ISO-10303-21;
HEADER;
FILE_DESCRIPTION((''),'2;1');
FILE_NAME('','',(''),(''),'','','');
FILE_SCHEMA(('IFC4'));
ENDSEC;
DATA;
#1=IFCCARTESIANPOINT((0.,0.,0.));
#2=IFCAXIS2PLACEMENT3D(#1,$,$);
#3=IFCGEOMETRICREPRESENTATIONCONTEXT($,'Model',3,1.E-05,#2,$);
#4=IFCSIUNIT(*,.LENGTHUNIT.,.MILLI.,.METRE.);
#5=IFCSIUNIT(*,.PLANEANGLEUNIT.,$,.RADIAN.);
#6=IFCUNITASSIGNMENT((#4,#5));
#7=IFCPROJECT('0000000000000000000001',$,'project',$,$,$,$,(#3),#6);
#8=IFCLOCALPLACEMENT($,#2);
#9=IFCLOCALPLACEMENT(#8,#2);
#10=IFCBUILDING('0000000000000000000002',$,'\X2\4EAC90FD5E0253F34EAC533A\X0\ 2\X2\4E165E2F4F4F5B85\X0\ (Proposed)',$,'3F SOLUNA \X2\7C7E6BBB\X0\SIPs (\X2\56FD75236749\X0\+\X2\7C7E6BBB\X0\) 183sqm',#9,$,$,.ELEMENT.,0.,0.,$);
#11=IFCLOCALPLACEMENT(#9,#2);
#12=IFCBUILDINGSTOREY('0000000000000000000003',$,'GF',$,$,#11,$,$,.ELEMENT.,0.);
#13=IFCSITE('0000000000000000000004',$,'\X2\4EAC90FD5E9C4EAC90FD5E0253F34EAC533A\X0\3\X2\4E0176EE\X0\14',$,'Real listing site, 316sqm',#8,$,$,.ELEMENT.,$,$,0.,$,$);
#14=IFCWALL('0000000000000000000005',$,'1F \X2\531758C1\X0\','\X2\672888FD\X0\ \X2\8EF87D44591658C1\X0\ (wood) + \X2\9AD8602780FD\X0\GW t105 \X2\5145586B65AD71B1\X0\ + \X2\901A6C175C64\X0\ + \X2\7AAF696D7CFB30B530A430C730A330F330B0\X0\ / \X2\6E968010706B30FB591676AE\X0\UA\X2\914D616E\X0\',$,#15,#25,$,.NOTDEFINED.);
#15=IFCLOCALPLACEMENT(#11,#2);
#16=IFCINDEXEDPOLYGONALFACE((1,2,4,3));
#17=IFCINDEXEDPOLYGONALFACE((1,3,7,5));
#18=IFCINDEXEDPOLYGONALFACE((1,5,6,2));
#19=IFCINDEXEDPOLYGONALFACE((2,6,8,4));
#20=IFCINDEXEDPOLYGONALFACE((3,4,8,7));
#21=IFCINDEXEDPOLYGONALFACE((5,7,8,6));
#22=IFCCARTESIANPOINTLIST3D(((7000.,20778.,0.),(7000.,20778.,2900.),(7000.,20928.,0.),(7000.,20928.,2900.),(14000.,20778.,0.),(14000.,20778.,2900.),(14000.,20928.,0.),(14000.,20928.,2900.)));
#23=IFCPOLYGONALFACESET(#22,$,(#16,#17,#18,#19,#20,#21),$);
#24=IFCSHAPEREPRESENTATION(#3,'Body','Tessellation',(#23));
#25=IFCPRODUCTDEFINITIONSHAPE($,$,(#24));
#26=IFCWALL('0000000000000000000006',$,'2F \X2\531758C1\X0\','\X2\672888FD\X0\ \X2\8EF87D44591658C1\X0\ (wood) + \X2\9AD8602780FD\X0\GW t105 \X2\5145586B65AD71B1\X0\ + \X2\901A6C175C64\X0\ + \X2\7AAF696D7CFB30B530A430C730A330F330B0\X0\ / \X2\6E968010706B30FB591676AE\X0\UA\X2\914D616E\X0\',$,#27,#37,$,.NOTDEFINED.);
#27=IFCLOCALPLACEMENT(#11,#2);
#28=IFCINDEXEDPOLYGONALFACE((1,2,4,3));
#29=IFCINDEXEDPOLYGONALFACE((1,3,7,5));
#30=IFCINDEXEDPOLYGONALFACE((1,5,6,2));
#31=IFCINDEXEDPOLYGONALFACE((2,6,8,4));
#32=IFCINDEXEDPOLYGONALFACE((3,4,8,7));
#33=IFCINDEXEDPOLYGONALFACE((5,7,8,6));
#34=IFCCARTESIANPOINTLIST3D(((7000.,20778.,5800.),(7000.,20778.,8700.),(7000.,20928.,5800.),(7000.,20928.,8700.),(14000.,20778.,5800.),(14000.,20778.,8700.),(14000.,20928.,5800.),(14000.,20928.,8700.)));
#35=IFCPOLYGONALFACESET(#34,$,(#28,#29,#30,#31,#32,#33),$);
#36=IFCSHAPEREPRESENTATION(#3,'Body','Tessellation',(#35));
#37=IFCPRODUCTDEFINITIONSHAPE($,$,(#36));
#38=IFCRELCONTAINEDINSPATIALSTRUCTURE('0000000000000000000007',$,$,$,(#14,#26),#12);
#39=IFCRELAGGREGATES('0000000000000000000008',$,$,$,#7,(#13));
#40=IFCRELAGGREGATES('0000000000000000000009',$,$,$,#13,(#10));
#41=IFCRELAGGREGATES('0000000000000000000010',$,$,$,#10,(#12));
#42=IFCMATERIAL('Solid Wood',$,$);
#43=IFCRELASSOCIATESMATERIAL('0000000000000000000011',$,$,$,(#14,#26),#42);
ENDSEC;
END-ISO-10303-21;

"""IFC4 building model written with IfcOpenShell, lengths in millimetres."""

from ifc_helpers import new_model, si_unit, frame, frame_2d, origin, place, context, project, spatial, rectangle, extrude, material, element, save


model = new_model("IFC4")

# Units and contexts
model_context = context("Model", 3, precision=1e-05, world=origin())
ifc_project = project(units=[si_unit("LENGTHUNIT", "METRE", prefix="MILLI"), si_unit("PLANEANGLEUNIT", "RADIAN")], contexts=[model_context])

# Site, building, storey
site_placement = place(None, origin())
site = spatial("IfcSite", under=ifc_project, at=site_placement, Name="京都府京都市右京区3丁目14", ObjectType="Real listing site, 316sqm", CompositionType="ELEMENT", RefElevation=0.0)
building_placement = place(site_placement, origin())
building = spatial("IfcBuilding", under=site, at=building_placement, Name="京都市右京区 2世帯住宅 (Proposed)", ObjectType="3F SOLUNA 籾殻SIPs (国産杉+籾殻) 183sqm", CompositionType="ELEMENT", ElevationOfRefHeight=0.0, ElevationOfTerrain=0.0)
storey_placement = place(building_placement, origin())
storey = spatial("IfcBuildingStorey", under=building, at=storey_placement, Name="GF", CompositionType="ELEMENT", Elevation=0.0)

# Shared definitions
ifc_material_1 = material(Name="Solid Wood")

# Wall
wall_1_placement = place(storey_placement, frame((3500.0, 10389.0, 0.0)))
element("IfcWall", 1, at=wall_1_placement, inside=storey, material=ifc_material_1, Name="1F 北壁", Description="木製 軸組外壁 (wood) + 高性能GW t105 充填断熱 + 通気層 + 窯業系サイディング / 準耐火・外皮UA配慮", PredefinedType="NOTDEFINED", context=model_context, shape_type="SweptSolid", body=[
    extrude(rectangle(XDim=7000.0, YDim=150.0, at=frame_2d((3500.0, 75.0))), frame((3500.0, 10389.0, 0.0)), (0.0, 0.0, 1.0), 2900.0),
])

# Wall
wall_2_placement = place(storey_placement, frame((3500.0, 10389.0, 2900.0)))
element("IfcWall", 2, at=wall_2_placement, inside=storey, material=ifc_material_1, Name="2F 北壁", Description="木製 軸組外壁 (wood) + 高性能GW t105 充填断熱 + 通気層 + 窯業系サイディング / 準耐火・外皮UA配慮", PredefinedType="NOTDEFINED", context=model_context, shape_type="SweptSolid", body=[
    extrude(rectangle(XDim=7000.0, YDim=150.0, at=frame_2d((3500.0, 75.0))), frame((3500.0, 10389.0, 2900.0)), (0.0, 0.0, 1.0), 2900.0),
])

save(model, "model.ifc")
